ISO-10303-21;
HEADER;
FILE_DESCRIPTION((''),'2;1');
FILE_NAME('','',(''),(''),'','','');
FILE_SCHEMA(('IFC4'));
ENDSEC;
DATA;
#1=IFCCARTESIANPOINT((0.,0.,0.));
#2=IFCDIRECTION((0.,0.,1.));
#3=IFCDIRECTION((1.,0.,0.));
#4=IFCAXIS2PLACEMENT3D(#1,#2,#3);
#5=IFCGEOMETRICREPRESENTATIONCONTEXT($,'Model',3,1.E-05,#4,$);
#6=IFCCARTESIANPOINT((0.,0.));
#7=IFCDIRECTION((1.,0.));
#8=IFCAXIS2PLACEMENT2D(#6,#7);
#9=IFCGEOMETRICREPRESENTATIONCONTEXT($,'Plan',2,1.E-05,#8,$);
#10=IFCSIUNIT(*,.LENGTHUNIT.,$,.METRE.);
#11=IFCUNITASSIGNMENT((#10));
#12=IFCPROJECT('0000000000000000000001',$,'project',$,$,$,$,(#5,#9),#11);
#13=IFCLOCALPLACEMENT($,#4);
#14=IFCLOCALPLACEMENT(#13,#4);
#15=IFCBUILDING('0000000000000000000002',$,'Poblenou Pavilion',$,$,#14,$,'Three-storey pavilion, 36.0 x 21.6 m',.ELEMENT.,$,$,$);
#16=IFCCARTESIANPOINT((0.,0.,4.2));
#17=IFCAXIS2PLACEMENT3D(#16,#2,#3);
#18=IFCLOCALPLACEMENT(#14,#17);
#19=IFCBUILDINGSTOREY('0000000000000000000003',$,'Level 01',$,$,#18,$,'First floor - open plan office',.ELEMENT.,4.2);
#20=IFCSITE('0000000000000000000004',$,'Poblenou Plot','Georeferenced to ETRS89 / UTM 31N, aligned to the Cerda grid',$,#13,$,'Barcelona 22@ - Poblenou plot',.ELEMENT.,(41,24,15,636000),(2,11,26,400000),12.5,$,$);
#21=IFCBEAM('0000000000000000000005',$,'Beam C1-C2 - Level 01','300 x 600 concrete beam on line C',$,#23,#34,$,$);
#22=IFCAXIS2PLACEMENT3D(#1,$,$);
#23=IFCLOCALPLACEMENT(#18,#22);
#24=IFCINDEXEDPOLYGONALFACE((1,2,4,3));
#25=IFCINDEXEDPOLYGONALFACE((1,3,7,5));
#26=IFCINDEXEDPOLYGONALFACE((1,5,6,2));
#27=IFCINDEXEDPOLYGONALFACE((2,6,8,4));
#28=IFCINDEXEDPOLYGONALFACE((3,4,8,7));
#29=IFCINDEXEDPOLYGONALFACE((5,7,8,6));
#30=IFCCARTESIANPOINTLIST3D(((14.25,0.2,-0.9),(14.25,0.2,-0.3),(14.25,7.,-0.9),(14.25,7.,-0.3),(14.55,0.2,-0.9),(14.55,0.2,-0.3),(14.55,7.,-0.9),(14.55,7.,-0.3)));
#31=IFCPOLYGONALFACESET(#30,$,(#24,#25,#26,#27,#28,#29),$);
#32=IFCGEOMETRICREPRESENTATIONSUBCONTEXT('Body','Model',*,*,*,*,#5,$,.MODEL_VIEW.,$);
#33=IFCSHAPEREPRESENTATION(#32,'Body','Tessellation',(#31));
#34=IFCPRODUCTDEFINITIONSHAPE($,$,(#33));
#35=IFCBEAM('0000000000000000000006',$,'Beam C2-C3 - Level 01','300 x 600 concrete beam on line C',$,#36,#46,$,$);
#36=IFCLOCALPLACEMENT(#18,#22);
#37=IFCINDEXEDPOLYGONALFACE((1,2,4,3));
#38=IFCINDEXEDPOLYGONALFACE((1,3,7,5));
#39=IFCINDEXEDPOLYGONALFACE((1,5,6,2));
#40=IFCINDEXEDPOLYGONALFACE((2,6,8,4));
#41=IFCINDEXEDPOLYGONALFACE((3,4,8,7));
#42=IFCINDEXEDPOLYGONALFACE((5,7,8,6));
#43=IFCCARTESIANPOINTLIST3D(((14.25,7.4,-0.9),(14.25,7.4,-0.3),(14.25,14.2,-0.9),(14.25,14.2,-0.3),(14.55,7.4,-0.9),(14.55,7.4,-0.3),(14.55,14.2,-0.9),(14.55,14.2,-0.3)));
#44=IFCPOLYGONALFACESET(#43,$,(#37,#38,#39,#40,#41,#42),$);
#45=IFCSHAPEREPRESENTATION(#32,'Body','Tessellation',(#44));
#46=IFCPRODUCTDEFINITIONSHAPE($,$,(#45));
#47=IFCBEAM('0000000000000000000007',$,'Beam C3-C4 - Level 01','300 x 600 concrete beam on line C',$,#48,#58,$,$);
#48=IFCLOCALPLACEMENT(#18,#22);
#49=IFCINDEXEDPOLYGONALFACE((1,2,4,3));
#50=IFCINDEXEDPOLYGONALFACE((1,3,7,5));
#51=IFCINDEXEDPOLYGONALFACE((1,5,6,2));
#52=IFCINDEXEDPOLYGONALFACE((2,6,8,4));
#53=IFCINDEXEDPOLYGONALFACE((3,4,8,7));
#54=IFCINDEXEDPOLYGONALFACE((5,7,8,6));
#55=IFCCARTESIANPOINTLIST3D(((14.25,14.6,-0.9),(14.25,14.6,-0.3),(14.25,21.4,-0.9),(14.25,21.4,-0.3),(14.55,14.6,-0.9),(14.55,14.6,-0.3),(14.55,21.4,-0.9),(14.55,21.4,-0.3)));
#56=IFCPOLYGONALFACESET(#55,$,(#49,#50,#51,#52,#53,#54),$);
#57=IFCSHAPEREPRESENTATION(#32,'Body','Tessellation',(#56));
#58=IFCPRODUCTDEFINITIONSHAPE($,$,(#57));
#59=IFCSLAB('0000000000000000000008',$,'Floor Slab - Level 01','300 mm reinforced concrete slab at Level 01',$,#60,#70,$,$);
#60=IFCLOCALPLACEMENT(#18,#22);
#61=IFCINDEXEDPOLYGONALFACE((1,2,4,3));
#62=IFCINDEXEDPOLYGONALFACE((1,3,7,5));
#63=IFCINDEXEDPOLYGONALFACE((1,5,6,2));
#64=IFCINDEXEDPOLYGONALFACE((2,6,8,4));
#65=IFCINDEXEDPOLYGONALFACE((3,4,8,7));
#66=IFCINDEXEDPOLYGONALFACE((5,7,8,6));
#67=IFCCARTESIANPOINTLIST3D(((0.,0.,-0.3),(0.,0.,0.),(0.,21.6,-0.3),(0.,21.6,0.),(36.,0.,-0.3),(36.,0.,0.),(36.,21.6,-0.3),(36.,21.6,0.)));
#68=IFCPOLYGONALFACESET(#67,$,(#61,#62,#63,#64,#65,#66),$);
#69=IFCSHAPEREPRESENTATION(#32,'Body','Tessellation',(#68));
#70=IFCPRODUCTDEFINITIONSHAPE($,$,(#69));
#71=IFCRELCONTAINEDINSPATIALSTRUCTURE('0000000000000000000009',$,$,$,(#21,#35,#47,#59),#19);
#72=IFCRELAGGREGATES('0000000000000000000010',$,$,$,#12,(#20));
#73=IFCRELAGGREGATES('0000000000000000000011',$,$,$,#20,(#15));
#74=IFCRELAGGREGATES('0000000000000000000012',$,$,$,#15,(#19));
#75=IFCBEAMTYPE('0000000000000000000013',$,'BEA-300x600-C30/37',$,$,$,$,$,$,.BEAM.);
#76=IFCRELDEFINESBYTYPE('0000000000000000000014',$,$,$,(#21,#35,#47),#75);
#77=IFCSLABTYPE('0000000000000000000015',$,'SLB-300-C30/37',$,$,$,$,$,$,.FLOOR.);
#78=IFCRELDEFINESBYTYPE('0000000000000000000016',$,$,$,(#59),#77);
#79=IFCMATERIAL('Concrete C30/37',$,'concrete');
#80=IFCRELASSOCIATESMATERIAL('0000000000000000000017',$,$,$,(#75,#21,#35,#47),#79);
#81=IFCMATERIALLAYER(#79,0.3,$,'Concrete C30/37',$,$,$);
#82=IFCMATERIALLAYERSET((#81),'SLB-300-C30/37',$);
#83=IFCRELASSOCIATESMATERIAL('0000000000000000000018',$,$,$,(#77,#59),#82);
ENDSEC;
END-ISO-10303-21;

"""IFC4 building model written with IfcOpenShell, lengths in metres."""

from ifc_helpers import new_model, si_unit, frame, origin_with_axes, origin_2d_with_axis, place, context, subcontext, project, spatial, line, indexed_curve, rectangle, outline, extrude, material, layer, layer_set, layer_usage, material_profile, profile_set, profile_usage, type_object, element, save


model = new_model("IFC4")

# Units and contexts
model_context = context("Model", 3, precision=1e-05, world=origin_with_axes())
plan_context = context("Plan", 2, precision=1e-05, world=origin_2d_with_axis())
body_context = subcontext(model_context, "Body", "Model", "MODEL_VIEW")
ifc_project = project(units=[si_unit("LENGTHUNIT", "METRE")], contexts=[model_context, plan_context])

# Site, building, storey
site_placement = place(None, origin_with_axes())
site = spatial("IfcSite", under=ifc_project, at=site_placement, Name="Poblenou Plot", Description="Georeferenced to ETRS89 / UTM 31N, aligned to the Cerda grid", LongName="Barcelona 22@ - Poblenou plot", CompositionType="ELEMENT", RefLatitude=(41, 24, 15, 636000), RefLongitude=(2, 11, 26, 400000), RefElevation=12.5)
building_placement = place(site_placement, origin_with_axes())
building = spatial("IfcBuilding", under=site, at=building_placement, Name="Poblenou Pavilion", LongName="Three-storey pavilion, 36.0 x 21.6 m", CompositionType="ELEMENT")
storey_placement = place(building_placement, frame((0.0, 0.0, 4.2), z_axis=(0.0, 0.0, 1.0), x_axis=(1.0, 0.0, 0.0)))
storey = spatial("IfcBuildingStorey", under=building, at=storey_placement, Name="Level 01", LongName="First floor - open plan office", CompositionType="ELEMENT", Elevation=4.2)

# Shared definitions
ifc_material = material(Name="Concrete C30/37", Category="concrete")

# Beams
ifc_material_profile_1 = material_profile(ifc_material, rectangle(XDim=0.3, YDim=0.6))
ifc_profile_set_1 = profile_set([ifc_material_profile_1], Name="BEA-300x600-C30/37")
beam_type = type_object("IfcBeamType", Name="BEA-300x600-C30/37", PredefinedType="BEAM", material=ifc_profile_set_1)
ifc_profile_usage_1 = profile_usage(ifc_profile_set_1)
beam_1_placement = place(storey_placement, frame((14.25, 0.2, -0.9), z_axis=(0.0, 1.0, 0.0), x_axis=(0.0, 0.0, 1.0)))
element("IfcBeam", 1, at=beam_1_placement, inside=storey, type_object=beam_type, material=ifc_profile_usage_1, Name="Beam C1-C2 - Level 01", Description="300 x 600 concrete beam on line C", context=body_context, shape_type="SweptSolid", body=[
    extrude(outline(indexed_curve([(0.0, 0.0), (0.6, 0.0), (0.6, 0.3), (0.0, 0.3)], segments=[line(1, 2, 3, 4, 1)])), origin_with_axes(), (0.0, 0.0, 1.0), 6.8),
])
ifc_profile_usage_2 = profile_usage(ifc_profile_set_1)
beam_2_placement = place(storey_placement, frame((14.25, 7.4, -0.9), z_axis=(0.0, 1.0, 0.0), x_axis=(0.0, 0.0, 1.0)))
element("IfcBeam", 2, at=beam_2_placement, inside=storey, type_object=beam_type, material=ifc_profile_usage_2, Name="Beam C2-C3 - Level 01", Description="300 x 600 concrete beam on line C", context=body_context, shape_type="SweptSolid", body=[
    extrude(outline(indexed_curve([(0.0, 0.0), (0.6, 0.0), (0.6, 0.3), (0.0, 0.3)], segments=[line(1, 2, 3, 4, 1)])), origin_with_axes(), (0.0, 0.0, 1.0), 6.8),
])
ifc_profile_usage_3 = profile_usage(ifc_profile_set_1)
beam_3_placement = place(storey_placement, frame((14.25, 14.6, -0.9), z_axis=(0.0, 1.0, 0.0), x_axis=(0.0, 0.0, 1.0)))
element("IfcBeam", 3, at=beam_3_placement, inside=storey, type_object=beam_type, material=ifc_profile_usage_3, Name="Beam C3-C4 - Level 01", Description="300 x 600 concrete beam on line C", context=body_context, shape_type="SweptSolid", body=[
    extrude(outline(indexed_curve([(0.0, 0.0), (0.6, 0.0), (0.6, 0.3), (0.0, 0.3)], segments=[line(1, 2, 3, 4, 1)])), origin_with_axes(), (0.0, 0.0, 1.0), 6.8),
])

# Slab
ifc_layer = layer(ifc_material, 0.3, Name="Concrete C30/37")
ifc_layer_set = layer_set([ifc_layer], Name="SLB-300-C30/37")
ifc_layer_usage = layer_usage(ifc_layer_set, "AXIS3", "POSITIVE", 0.0)
slab_type = type_object("IfcSlabType", Name="SLB-300-C30/37", PredefinedType="FLOOR", material=ifc_layer_set)
slab_placement = place(storey_placement, frame((0.0, 0.0, -0.3), z_axis=(0.0, 0.0, 1.0), x_axis=(1.0, 0.0, 0.0)))
element("IfcSlab", 4, at=slab_placement, inside=storey, type_object=slab_type, material=ifc_layer_usage, Name="Floor Slab - Level 01", Description="300 mm reinforced concrete slab at Level 01", context=body_context, shape_type="SweptSolid", body=[
    extrude(outline(indexed_curve([(0.0, 0.0), (36.0, 0.0), (36.0, 21.6), (0.0, 21.6)], segments=[line(1, 2, 3, 4, 1)])), origin_with_axes(), (0.0, 0.0, 1.0), 0.3),
])

save(model, "model.ifc")
